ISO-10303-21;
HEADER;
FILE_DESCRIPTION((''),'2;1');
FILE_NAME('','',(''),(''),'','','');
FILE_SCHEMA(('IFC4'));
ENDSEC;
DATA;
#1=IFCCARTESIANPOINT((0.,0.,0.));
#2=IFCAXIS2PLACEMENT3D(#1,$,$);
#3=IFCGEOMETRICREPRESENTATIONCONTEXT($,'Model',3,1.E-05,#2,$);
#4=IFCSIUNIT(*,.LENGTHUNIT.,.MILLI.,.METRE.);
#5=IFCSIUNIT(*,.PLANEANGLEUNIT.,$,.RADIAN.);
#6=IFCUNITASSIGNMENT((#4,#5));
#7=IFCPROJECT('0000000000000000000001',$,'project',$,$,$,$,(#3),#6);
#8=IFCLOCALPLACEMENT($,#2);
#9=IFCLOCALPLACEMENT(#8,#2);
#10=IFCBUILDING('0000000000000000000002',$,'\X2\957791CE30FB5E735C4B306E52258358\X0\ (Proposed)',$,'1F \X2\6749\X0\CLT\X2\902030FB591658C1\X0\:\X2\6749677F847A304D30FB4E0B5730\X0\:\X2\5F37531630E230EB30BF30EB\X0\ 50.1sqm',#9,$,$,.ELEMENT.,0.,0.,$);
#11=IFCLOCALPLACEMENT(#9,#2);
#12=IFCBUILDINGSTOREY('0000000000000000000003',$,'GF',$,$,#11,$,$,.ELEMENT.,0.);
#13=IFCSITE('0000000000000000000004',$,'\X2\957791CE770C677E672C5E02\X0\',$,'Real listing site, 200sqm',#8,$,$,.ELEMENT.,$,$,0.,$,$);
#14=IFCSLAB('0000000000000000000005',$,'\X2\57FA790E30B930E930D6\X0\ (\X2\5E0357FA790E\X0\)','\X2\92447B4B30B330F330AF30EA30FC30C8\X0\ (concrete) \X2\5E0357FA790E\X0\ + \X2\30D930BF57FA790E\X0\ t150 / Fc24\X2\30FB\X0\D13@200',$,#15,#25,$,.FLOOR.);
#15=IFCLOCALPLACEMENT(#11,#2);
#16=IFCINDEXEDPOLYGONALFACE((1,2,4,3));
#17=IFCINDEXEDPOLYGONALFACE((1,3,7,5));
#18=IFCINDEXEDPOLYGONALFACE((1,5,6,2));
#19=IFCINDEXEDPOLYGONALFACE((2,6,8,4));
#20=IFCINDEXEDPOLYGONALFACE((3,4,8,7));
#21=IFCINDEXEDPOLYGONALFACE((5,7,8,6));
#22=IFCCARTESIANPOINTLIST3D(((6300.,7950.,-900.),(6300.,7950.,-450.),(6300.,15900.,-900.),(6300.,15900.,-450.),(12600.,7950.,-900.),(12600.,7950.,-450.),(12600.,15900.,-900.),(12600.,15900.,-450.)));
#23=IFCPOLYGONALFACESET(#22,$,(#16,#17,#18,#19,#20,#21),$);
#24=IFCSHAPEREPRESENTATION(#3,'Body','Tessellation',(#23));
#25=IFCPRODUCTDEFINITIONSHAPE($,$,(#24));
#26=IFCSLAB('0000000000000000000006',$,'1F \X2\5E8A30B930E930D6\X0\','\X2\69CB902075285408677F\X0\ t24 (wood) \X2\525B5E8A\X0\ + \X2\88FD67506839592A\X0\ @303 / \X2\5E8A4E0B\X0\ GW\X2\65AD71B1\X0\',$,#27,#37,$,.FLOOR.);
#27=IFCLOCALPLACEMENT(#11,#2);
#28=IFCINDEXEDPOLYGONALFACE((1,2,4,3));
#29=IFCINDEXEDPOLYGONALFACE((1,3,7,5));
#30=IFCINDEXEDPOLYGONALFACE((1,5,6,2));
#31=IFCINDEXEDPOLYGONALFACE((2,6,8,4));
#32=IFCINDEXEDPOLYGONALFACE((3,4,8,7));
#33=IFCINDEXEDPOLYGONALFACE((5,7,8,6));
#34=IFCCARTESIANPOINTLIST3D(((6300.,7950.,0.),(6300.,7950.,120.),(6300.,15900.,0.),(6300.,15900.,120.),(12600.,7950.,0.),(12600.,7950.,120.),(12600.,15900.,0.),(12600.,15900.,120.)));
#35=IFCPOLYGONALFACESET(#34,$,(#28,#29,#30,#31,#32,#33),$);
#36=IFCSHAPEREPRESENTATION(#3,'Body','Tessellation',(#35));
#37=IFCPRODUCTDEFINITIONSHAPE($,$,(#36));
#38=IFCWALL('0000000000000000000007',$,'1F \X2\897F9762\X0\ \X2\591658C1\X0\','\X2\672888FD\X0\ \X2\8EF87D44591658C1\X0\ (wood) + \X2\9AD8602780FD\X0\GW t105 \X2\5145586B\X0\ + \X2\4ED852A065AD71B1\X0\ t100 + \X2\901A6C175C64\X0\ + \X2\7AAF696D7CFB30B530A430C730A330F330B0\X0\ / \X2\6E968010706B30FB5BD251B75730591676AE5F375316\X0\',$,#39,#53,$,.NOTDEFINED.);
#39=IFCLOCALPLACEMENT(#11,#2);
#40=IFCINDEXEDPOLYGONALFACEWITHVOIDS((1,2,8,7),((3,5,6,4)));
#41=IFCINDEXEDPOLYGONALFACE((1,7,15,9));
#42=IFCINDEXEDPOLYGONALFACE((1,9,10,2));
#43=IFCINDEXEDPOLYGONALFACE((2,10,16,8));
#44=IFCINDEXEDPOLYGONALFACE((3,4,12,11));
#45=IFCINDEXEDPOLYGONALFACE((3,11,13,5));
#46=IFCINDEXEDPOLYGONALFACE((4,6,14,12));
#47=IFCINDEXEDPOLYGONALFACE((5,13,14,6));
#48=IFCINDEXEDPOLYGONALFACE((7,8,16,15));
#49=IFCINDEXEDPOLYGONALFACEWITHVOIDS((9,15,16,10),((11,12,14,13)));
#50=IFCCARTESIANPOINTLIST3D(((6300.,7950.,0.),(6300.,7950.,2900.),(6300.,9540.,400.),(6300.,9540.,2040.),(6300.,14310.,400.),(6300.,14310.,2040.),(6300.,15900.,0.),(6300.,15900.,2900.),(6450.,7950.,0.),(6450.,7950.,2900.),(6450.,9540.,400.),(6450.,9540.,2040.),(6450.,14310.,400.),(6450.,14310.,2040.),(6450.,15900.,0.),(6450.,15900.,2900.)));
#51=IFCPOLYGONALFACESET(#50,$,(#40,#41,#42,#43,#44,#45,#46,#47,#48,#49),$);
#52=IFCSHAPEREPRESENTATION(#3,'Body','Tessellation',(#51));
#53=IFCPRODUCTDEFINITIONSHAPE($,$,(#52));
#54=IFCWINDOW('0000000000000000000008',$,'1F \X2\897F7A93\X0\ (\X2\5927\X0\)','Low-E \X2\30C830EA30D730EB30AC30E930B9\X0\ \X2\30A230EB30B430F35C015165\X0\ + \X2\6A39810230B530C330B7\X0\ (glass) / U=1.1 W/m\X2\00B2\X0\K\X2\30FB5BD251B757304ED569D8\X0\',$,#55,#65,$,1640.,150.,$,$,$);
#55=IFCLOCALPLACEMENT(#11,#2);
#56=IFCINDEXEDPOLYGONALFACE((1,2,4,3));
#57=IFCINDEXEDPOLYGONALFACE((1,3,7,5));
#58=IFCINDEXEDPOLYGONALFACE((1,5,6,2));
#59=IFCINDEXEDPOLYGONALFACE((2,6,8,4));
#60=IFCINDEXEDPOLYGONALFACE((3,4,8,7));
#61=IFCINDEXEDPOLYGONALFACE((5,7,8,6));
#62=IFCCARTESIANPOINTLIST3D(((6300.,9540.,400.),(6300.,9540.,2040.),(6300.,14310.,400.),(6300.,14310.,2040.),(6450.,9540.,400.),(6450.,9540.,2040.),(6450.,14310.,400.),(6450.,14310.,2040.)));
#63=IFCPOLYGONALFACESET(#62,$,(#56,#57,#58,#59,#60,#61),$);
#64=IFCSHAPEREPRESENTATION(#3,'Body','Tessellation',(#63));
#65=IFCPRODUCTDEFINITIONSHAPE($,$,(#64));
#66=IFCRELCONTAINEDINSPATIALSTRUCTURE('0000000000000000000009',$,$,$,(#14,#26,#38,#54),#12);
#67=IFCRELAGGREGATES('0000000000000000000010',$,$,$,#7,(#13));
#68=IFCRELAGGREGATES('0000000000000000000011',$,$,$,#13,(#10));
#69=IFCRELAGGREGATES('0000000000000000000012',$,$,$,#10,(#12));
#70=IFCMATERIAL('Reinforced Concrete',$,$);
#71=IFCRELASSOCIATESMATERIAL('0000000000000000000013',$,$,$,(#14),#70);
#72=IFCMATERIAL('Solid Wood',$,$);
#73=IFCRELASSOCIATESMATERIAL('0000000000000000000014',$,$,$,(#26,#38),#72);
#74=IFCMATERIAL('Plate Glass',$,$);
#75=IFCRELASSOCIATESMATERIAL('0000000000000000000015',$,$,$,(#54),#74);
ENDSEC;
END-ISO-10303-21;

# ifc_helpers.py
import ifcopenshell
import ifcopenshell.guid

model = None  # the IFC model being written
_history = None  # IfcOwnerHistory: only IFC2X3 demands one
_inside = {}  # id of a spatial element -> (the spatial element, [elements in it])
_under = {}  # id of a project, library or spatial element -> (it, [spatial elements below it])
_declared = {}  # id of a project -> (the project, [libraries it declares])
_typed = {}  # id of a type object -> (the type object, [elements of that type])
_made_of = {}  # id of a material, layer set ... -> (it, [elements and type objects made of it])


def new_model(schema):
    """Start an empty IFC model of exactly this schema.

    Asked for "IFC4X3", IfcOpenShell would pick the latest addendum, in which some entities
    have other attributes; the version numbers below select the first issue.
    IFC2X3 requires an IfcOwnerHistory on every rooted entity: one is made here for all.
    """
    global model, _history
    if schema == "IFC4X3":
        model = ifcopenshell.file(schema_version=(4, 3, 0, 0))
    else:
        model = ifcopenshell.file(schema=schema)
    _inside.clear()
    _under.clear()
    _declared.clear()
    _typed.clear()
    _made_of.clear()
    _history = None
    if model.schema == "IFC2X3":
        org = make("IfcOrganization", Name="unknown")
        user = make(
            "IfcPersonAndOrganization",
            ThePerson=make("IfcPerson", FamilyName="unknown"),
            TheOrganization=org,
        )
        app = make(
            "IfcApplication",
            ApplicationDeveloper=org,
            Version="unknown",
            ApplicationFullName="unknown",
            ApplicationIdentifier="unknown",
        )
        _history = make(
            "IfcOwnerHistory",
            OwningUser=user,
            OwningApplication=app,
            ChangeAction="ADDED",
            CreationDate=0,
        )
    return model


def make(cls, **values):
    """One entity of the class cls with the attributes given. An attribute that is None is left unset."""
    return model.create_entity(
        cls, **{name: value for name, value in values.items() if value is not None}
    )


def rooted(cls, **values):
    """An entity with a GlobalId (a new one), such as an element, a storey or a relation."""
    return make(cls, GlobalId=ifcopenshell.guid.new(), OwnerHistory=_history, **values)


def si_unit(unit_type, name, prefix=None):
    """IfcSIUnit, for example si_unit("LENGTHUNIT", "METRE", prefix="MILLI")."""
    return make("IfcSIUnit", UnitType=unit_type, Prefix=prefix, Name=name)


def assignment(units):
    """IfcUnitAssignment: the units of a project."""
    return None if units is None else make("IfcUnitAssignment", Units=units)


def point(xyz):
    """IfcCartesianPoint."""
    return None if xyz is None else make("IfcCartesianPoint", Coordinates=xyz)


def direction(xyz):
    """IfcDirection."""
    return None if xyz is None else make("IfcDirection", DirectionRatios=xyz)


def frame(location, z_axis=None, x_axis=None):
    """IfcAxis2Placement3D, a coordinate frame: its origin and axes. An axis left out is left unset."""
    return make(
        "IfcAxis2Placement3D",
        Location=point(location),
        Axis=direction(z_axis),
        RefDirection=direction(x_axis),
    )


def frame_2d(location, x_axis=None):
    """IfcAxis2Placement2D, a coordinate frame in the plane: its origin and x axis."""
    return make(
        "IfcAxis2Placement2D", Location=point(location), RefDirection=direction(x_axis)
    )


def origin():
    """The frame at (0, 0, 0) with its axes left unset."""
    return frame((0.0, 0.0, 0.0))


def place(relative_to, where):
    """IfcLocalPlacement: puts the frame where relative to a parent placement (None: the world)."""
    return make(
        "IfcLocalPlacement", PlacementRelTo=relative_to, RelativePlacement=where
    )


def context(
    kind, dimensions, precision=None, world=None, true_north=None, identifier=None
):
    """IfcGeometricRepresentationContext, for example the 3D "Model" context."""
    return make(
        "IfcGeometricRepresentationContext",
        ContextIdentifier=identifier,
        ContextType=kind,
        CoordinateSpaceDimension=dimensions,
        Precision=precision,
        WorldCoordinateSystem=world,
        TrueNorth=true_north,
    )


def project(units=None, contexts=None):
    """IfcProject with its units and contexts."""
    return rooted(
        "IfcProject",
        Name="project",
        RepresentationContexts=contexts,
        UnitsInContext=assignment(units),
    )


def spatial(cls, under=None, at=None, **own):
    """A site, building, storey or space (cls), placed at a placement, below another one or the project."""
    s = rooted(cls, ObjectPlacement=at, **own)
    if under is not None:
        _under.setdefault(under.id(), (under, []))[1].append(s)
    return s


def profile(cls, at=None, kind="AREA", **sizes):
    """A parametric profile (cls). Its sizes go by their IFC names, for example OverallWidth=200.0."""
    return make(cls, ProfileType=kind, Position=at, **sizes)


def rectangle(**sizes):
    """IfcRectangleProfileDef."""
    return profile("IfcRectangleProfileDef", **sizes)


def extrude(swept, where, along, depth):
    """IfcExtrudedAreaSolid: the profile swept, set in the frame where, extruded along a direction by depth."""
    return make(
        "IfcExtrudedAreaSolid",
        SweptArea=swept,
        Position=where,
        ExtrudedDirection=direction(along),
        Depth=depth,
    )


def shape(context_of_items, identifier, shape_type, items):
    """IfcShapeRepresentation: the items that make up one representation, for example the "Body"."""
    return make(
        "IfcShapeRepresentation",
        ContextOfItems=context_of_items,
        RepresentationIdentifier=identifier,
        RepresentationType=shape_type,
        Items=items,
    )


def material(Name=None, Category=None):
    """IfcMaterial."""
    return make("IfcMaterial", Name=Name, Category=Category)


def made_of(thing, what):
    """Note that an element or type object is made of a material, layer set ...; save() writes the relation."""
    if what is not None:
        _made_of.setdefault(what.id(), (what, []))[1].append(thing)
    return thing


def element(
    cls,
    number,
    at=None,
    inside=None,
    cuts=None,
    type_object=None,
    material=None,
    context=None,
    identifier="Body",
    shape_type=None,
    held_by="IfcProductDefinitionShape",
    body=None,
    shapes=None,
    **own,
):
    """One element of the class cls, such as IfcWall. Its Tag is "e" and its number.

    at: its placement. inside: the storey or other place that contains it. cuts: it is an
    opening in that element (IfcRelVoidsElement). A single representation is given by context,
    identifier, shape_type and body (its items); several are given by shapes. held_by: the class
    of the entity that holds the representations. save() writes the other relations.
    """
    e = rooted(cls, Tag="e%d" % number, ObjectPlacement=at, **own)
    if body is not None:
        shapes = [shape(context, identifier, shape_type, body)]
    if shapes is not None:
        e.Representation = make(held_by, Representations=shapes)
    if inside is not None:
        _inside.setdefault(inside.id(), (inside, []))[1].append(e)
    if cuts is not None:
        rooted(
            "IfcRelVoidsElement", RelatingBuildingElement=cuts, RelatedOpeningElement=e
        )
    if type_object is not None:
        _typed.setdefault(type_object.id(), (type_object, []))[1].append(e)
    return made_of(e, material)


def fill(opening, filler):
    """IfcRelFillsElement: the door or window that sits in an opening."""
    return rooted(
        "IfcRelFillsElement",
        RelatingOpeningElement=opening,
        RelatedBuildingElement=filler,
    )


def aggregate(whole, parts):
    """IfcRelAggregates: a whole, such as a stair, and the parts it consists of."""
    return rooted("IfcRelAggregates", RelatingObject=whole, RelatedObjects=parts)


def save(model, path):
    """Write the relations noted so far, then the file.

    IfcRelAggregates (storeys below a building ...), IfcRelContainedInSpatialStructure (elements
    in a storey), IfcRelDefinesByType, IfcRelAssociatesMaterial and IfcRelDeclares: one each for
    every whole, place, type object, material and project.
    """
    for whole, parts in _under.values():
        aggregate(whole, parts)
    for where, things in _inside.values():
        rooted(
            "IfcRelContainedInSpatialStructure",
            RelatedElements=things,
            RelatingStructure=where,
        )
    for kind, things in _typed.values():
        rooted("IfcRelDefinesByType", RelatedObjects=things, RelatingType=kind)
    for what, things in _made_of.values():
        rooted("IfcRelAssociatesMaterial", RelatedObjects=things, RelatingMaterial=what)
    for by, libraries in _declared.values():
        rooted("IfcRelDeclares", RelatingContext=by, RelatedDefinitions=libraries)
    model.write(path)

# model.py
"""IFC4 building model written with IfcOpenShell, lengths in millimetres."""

from ifc_helpers import new_model, si_unit, frame, frame_2d, origin, place, context, project, spatial, rectangle, extrude, material, element, fill, save


model = new_model("IFC4")

# Units and contexts
model_context = context("Model", 3, precision=1e-05, world=origin())
ifc_project = project(units=[si_unit("LENGTHUNIT", "METRE", prefix="MILLI"), si_unit("PLANEANGLEUNIT", "RADIAN")], contexts=[model_context])

# Site, building, storey
site_placement = place(None, origin())
site = spatial("IfcSite", under=ifc_project, at=site_placement, Name="長野県松本市", ObjectType="Real listing site, 200sqm", CompositionType="ELEMENT", RefElevation=0.0)
building_placement = place(site_placement, origin())
building = spatial("IfcBuilding", under=site, at=building_placement, Name="長野・平屋の別荘 (Proposed)", ObjectType="1F 杉CLT造・外壁:杉板葺き・下地:強化モルタル 50.1sqm", CompositionType="ELEMENT", ElevationOfRefHeight=0.0, ElevationOfTerrain=0.0)
storey_placement = place(building_placement, origin())
storey = spatial("IfcBuildingStorey", under=building, at=storey_placement, Name="GF", CompositionType="ELEMENT", Elevation=0.0)

# Shared definitions
ifc_material_1 = material(Name="Solid Wood")

# Slabs
ifc_material_2 = material(Name="Reinforced Concrete")
slab_1_placement = place(storey_placement, frame((3150.0, 3975.0, -450.0)))
element("IfcSlab", 1, at=slab_1_placement, inside=storey, material=ifc_material_2, Name="基礎スラブ (布基礎)", Description="鉄筋コンクリート (concrete) 布基礎 + ベタ基礎 t150 / Fc24・D13@200", PredefinedType="FLOOR", context=model_context, shape_type="SweptSolid", body=[
    extrude(rectangle(XDim=6300.0, YDim=7950.0, at=frame_2d((3150.0, 3975.0))), frame((3150.0, 3975.0, -450.0)), (0.0, 0.0, 1.0), 450.0),
])
slab_2_placement = place(storey_placement, frame((3150.0, 3975.0, 0.0)))
element("IfcSlab", 2, at=slab_2_placement, inside=storey, material=ifc_material_1, Name="1F 床スラブ", Description="構造用合板 t24 (wood) 剛床 + 製材根太 @303 / 床下 GW断熱", PredefinedType="FLOOR", context=model_context, shape_type="SweptSolid", body=[
    extrude(rectangle(XDim=6300.0, YDim=7950.0, at=frame_2d((3150.0, 3975.0))), frame((3150.0, 3975.0, 0.0)), (0.0, 0.0, 1.0), 120.0),
])

# Shared definitions
ifc_material_3 = material(Name="Plate Glass")

# Wall, opening, window
wall_1_placement = place(storey_placement, frame((3150.0, 3975.0, 0.0)))
wall_1 = element("IfcWall", 3, at=wall_1_placement, inside=storey, material=ifc_material_1, Name="1F 西面 外壁", Description="木製 軸組外壁 (wood) + 高性能GW t105 充填 + 付加断熱 t100 + 通気層 + 窯業系サイディング / 準耐火・寒冷地外皮強化", PredefinedType="NOTDEFINED", context=model_context, shape_type="SweptSolid", body=[
    extrude(rectangle(XDim=150.0, YDim=7950.0, at=frame_2d((75.0, 3975.0))), frame((3150.0, 3975.0, 0.0)), (0.0, 0.0, 1.0), 2900.0),
])
opening_1_placement = place(storey_placement, frame((3150.0, 4770.0, 200.0)))
opening_1 = element("IfcOpeningElement", 4, at=opening_1_placement, cuts=wall_1, PredefinedType="NOTDEFINED", context=model_context, shape_type="SweptSolid", body=[
    extrude(rectangle(XDim=150.0, YDim=4770.0, at=frame_2d((75.0, 2385.0))), frame((3150.0, 4770.0, 200.0)), (0.0, 0.0, 1.0), 1640.0),
])
window_1_placement = place(storey_placement, frame((3150.0, 4770.0, 200.0)))
window_1 = element("IfcWindow", 5, at=window_1_placement, inside=storey, material=ifc_material_3, Name="1F 西窓 (大)", Description="Low-E トリプルガラス アルゴン封入 + 樹脂サッシ (glass) / U=1.1 W/m²K・寒冷地仕様", OverallHeight=1640.0, OverallWidth=150.0, context=model_context, shape_type="SweptSolid", body=[
    extrude(rectangle(XDim=150.0, YDim=4770.0, at=frame_2d((75.0, 2385.0))), frame((3150.0, 4770.0, 200.0)), (0.0, 0.0, 1.0), 1640.0),
])
fill(opening_1, window_1)

save(model, "model.ifc")
